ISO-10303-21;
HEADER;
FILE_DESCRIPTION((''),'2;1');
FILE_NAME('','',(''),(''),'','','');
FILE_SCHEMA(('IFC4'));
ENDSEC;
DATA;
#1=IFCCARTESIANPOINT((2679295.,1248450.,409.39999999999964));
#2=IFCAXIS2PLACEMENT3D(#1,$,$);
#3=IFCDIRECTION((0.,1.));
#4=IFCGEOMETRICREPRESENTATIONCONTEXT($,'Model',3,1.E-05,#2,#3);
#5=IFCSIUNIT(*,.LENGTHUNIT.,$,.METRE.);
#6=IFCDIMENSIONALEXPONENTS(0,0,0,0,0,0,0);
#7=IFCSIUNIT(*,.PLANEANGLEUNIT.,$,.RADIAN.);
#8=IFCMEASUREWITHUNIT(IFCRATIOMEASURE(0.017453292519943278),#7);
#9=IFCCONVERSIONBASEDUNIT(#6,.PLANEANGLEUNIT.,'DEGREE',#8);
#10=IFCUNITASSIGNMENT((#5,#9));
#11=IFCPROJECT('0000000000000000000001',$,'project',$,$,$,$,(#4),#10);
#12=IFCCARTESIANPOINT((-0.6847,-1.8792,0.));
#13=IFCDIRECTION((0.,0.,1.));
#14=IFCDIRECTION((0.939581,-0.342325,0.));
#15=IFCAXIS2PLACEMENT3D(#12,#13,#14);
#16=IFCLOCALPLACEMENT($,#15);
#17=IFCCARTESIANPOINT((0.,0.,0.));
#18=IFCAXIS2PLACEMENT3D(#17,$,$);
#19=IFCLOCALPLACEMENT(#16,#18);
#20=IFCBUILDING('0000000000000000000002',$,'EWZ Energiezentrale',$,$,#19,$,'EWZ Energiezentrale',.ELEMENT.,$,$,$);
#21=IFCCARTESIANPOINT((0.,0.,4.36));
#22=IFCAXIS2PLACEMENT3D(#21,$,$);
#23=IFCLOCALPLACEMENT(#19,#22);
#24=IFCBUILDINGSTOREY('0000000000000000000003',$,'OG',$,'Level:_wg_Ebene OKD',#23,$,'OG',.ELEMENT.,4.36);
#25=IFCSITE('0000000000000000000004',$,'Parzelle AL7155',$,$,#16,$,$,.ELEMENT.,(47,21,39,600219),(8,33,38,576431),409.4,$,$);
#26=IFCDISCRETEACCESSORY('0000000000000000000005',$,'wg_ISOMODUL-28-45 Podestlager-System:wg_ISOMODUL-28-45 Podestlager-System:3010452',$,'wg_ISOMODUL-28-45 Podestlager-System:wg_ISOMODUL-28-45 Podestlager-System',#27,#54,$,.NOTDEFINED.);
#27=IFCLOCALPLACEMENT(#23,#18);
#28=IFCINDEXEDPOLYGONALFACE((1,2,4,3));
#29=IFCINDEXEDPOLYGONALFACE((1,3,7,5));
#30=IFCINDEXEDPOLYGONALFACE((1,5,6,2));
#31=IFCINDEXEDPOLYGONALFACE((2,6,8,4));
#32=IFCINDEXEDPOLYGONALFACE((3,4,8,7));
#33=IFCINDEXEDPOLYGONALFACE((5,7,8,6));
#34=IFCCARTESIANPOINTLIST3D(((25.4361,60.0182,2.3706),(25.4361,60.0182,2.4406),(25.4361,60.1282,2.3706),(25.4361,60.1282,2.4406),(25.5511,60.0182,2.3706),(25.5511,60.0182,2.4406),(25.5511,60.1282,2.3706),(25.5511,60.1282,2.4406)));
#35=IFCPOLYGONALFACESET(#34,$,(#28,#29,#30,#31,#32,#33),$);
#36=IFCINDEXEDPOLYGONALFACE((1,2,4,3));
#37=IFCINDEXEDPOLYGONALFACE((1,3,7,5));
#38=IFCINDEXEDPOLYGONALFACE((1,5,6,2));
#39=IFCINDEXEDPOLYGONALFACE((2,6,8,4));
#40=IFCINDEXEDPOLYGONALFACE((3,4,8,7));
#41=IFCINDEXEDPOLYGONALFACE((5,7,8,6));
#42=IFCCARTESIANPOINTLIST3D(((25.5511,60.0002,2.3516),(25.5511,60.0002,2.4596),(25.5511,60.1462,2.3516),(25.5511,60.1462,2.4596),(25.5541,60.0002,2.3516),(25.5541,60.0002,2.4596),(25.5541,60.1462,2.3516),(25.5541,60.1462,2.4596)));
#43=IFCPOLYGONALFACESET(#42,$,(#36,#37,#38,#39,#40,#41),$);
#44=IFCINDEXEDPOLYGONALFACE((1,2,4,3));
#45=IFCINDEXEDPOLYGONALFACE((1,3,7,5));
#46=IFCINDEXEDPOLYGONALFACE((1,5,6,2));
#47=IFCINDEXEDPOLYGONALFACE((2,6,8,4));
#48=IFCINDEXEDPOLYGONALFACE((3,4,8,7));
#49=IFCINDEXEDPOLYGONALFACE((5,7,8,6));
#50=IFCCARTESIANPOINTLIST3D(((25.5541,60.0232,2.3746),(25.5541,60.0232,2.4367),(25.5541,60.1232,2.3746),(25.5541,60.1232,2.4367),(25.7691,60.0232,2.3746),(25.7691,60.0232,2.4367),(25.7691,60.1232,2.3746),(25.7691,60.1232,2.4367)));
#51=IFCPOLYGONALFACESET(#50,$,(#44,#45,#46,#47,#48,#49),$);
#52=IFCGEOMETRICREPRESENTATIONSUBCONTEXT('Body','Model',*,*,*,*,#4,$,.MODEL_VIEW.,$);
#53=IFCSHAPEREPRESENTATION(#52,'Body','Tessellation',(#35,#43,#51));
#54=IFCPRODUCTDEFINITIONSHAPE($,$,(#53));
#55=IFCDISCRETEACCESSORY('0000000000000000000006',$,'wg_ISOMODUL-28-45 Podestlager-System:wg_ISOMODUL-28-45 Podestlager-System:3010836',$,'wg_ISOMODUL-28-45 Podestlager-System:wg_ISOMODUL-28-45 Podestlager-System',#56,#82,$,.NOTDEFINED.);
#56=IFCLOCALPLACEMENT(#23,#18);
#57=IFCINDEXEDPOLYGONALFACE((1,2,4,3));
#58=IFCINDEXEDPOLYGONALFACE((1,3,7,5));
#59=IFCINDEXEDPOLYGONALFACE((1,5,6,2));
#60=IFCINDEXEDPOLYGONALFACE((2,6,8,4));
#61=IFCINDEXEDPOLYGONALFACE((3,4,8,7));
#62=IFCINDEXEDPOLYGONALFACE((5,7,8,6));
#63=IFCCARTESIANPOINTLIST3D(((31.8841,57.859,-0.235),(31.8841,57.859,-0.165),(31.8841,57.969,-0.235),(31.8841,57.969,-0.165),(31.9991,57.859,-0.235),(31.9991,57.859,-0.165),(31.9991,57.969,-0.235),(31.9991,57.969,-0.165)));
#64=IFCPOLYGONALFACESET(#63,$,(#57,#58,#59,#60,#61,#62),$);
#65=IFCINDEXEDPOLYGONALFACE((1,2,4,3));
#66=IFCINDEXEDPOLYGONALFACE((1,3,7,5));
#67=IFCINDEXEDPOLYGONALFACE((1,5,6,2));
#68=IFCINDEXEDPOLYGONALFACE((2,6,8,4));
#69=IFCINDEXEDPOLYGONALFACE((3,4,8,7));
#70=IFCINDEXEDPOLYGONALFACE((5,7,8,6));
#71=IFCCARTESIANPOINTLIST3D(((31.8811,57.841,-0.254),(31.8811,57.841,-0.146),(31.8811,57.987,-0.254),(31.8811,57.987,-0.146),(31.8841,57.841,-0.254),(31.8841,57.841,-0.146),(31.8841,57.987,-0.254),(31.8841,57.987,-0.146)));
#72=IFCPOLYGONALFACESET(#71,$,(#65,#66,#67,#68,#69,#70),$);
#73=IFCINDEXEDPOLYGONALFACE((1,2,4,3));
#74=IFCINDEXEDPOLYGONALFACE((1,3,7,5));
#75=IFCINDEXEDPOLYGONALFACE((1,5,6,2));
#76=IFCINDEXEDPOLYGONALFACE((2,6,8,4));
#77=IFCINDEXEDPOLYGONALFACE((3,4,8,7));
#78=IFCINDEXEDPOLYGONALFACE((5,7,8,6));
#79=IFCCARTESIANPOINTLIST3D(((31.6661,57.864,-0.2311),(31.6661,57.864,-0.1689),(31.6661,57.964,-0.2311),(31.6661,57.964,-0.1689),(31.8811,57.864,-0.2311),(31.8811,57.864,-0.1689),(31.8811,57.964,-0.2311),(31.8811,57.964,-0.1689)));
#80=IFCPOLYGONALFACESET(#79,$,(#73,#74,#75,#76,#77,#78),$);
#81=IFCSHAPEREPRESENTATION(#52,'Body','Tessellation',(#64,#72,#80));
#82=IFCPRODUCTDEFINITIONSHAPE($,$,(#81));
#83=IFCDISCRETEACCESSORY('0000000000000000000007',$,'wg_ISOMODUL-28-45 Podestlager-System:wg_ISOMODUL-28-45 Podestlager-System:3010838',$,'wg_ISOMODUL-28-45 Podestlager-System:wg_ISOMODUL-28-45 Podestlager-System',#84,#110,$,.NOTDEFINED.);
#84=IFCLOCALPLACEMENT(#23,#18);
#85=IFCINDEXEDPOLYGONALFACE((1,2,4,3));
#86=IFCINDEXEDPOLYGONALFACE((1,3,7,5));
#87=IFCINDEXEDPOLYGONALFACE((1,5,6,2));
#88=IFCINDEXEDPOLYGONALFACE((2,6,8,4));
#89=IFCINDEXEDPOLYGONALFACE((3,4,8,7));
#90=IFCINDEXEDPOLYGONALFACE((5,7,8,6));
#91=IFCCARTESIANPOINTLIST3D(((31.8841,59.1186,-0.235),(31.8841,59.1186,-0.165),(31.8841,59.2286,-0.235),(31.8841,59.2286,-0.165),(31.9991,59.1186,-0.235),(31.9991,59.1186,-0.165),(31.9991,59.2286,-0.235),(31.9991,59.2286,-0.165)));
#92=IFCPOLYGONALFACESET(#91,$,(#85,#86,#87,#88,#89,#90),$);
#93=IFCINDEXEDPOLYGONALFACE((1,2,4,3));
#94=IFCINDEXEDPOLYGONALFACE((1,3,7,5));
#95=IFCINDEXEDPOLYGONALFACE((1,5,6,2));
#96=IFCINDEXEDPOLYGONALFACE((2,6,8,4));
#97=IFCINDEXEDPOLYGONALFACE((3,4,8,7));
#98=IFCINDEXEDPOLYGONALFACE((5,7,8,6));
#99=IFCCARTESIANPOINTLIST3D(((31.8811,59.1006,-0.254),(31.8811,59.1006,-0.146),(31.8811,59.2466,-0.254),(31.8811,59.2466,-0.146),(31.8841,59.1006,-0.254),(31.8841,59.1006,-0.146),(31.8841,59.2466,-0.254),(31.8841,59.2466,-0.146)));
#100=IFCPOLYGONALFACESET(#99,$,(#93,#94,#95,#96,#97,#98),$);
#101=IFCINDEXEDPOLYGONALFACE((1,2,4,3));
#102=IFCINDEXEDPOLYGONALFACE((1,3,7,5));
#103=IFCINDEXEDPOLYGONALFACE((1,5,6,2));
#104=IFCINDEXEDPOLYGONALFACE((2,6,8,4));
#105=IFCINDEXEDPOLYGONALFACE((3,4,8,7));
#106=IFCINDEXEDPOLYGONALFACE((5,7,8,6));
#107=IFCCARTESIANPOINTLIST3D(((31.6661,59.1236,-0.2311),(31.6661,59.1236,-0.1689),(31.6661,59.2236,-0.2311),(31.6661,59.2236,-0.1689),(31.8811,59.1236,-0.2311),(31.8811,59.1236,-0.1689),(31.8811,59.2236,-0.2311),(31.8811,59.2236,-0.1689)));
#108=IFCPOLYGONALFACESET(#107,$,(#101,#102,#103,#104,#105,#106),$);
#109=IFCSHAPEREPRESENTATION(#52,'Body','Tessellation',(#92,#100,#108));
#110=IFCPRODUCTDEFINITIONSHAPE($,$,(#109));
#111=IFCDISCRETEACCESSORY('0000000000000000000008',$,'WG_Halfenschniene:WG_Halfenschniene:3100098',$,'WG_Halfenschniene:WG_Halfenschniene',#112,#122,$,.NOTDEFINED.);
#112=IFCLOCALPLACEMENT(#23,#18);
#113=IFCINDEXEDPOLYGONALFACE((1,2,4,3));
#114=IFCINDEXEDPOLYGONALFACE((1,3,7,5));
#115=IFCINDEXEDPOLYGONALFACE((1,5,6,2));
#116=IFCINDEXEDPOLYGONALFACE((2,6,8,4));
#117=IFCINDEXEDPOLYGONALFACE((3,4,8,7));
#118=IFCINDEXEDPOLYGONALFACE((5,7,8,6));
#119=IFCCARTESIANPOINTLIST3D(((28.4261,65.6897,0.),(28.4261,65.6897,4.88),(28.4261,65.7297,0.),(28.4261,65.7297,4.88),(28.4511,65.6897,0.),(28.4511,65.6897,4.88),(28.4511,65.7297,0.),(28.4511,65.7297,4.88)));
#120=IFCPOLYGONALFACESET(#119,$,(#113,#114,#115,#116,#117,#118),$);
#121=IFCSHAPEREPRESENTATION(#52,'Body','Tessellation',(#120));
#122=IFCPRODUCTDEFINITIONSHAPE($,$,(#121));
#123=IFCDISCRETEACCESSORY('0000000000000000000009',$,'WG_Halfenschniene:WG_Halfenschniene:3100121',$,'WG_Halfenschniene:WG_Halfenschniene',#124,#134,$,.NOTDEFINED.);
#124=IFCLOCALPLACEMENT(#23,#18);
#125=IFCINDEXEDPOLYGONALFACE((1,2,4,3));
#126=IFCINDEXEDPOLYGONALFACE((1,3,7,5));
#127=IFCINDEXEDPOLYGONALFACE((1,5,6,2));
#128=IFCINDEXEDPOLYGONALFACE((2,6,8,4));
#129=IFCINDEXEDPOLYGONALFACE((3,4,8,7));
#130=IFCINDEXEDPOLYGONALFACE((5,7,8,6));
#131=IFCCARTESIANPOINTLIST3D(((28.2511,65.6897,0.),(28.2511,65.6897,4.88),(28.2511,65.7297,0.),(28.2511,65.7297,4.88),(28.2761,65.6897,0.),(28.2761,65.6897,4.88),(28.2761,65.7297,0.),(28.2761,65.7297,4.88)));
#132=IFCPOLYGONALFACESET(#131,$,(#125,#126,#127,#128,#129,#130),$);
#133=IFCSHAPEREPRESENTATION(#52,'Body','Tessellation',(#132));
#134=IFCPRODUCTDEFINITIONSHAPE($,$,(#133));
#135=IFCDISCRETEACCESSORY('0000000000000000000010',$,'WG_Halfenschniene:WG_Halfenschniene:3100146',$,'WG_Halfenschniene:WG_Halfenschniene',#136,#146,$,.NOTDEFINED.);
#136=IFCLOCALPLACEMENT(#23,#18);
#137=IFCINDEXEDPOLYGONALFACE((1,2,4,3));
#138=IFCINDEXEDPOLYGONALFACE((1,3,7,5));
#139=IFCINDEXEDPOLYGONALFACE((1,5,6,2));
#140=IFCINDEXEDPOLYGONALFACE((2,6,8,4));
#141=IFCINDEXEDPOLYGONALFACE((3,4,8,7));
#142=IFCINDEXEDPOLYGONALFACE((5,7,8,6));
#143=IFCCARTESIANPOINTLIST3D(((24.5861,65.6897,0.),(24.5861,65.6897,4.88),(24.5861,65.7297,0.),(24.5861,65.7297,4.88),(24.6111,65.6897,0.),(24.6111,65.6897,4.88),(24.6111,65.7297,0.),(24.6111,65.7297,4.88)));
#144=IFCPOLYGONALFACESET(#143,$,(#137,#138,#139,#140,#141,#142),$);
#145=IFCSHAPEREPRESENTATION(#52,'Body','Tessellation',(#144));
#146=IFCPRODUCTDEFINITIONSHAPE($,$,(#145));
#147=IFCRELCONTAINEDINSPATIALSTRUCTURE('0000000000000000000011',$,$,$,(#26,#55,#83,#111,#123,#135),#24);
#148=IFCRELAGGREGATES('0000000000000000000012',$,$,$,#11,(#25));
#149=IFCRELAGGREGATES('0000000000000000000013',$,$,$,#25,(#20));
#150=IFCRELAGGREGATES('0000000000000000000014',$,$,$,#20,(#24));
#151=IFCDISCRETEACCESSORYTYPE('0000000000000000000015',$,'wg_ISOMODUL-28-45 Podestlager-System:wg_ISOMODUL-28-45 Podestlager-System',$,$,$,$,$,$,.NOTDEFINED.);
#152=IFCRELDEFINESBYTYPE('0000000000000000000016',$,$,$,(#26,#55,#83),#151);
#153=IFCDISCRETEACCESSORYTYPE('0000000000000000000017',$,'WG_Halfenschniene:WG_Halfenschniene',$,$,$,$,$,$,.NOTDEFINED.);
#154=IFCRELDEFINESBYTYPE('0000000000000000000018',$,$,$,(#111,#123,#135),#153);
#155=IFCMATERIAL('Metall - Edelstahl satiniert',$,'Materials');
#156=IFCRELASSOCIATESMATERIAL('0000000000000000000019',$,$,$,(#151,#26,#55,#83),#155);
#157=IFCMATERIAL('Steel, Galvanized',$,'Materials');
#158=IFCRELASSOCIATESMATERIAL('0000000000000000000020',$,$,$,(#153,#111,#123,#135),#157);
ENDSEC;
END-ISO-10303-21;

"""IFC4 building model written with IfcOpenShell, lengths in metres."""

from ifc_helpers import new_model, entity, si_unit, converted_unit, direction, frame, origin, place, context, subcontext, project, spatial, indexed_curve, outline, extrude, source, transform, mapped, material, type_object, element, save


model = new_model("IFC4")

# Units and contexts
model_context = context("Model", 3, precision=1e-05, world=frame((2679295.0, 1248450.0, 409.39999999999964)), true_north=direction((0.0, 1.0)))
body_context = subcontext(model_context, "Body", "Model", "MODEL_VIEW")
ifc_project = project(units=[si_unit("LENGTHUNIT", "METRE"), converted_unit("PLANEANGLEUNIT", "DEGREE", entity("IfcRatioMeasure", 0.017453292519943278), si_unit("PLANEANGLEUNIT", "RADIAN"), dimensions=[0, 0, 0, 0, 0, 0, 0])], contexts=[model_context])

# Site, building, storey
site_placement = place(None, frame((-0.6847, -1.8792, 0.0), z_axis=(0.0, 0.0, 1.0), x_axis=(0.939581, -0.342325, 0.0)))
site = spatial("IfcSite", under=ifc_project, at=site_placement, Name="Parzelle AL7155", CompositionType="ELEMENT", RefLatitude=(47, 21, 39, 600219), RefLongitude=(8, 33, 38, 576431), RefElevation=409.4)
building_placement = place(site_placement, origin())
building = spatial("IfcBuilding", under=site, at=building_placement, Name="EWZ Energiezentrale", LongName="EWZ Energiezentrale", CompositionType="ELEMENT")
storey_placement = place(building_placement, frame((0.0, 0.0, 4.36)))
storey = spatial("IfcBuildingStorey", under=building, at=storey_placement, Name="OG", ObjectType="Level:_wg_Ebene OKD", LongName="OG", CompositionType="ELEMENT", Elevation=4.36)

# Discrete accessories
ifc_material_1 = material(Name="Metall - Edelstahl satiniert", Category="Materials")
discrete_accessory_type_1 = type_object("IfcDiscreteAccessoryType", Name="wg_ISOMODUL-28-45 Podestlager-System:wg_ISOMODUL-28-45 Podestlager-System", PredefinedType="NOTDEFINED", material=ifc_material_1)
shared_shape_1 = source(origin(), body_context, "Body", "SweptSolid", [
    extrude(outline(indexed_curve([(-0.0575, -0.055), (0.0575, -0.055), (0.0575, 0.055), (-0.0575, 0.055), (-0.0575, -0.055)], self_intersect=False)), frame((0.0, 0.0575, 0.0), z_axis=(0.0, 0.0, 1.0), x_axis=(0.0, 1.0, 0.0)), (0.0, 0.0, 1.0), 0.07),
    extrude(outline(indexed_curve([(-0.0015, -0.073), (0.0015, -0.073), (0.0015, 0.073), (-0.0015, 0.073), (-0.0015, -0.073)], self_intersect=False)), frame((0.0, -0.0015, -0.019), z_axis=(0.0, 0.0, 1.0), x_axis=(0.0, 1.0, 0.0)), (0.0, 0.0, 1.0), 0.108),
    extrude(outline(indexed_curve([(-0.1075, -0.05), (0.1075, -0.05), (0.1075, 0.05), (-0.1075, 0.05), (-0.1075, -0.05)], self_intersect=False)), frame((0.0, -0.1105, 0.0039), z_axis=(0.0, 0.0, 1.0), x_axis=(0.0, 1.0, 0.0)), (0.0, 0.0, 1.0), 0.0621),
])
for number, where, z_axis, x_axis, name in (
    (1, (25.5511, 60.0732, 2.3706), (0.0, 0.0, 1.0), (0.0, 1.0, 0.0), "wg_ISOMODUL-28-45 Podestlager-System:wg_ISOMODUL-28-45 Podestlager-System:3010452"),
    (2, (31.8841, 57.914, -0.235), (0.0, 0.0, 1.0), (0.0, -1.0, 0.0), "wg_ISOMODUL-28-45 Podestlager-System:wg_ISOMODUL-28-45 Podestlager-System:3010836"),
    (3, (31.8841, 59.1736, -0.235), (0.0, 0.0, 1.0), (0.0, -1.0, 0.0), "wg_ISOMODUL-28-45 Podestlager-System:wg_ISOMODUL-28-45 Podestlager-System:3010838"),
):
    element("IfcDiscreteAccessory", number, at=place(storey_placement, frame(where, z_axis=z_axis, x_axis=x_axis)), inside=storey, type_object=discrete_accessory_type_1, material=ifc_material_1, Name=name, ObjectType="wg_ISOMODUL-28-45 Podestlager-System:wg_ISOMODUL-28-45 Podestlager-System", PredefinedType="NOTDEFINED", context=body_context, shape_type="MappedRepresentation", body=[
        mapped(shared_shape_1, transform((0.0, 0.0, 0.0), scale=1.0)),
    ])
ifc_material_2 = material(Name="Steel, Galvanized", Category="Materials")
discrete_accessory_type_2 = type_object("IfcDiscreteAccessoryType", Name="WG_Halfenschniene:WG_Halfenschniene", PredefinedType="NOTDEFINED", material=ifc_material_2)
shared_shape_2 = source(origin(), body_context, "Body", "SweptSolid", [
    extrude(outline(indexed_curve([(-2.44, -0.02), (2.44, -0.02), (2.44, 0.02), (-2.44, 0.02), (-2.44, -0.02)], self_intersect=False)), frame((2.44, 0.0, -0.0125)), (0.0, 0.0, 1.0), 0.025),
])
for number, where, z_axis, x_axis, name in (
    (4, (28.4386, 65.7097, 4.88), (1.0, 0.0, 0.0), (0.0, 0.0, -1.0), "WG_Halfenschniene:WG_Halfenschniene:3100098"),
    (5, (28.2636, 65.7097, 0.0), (-1.0, 0.0, 0.0), (0.0, 0.0, 1.0), "WG_Halfenschniene:WG_Halfenschniene:3100121"),
    (6, (24.5986, 65.7097, 4.88), (1.0, 0.0, 0.0), (0.0, 0.0, -1.0), "WG_Halfenschniene:WG_Halfenschniene:3100146"),
):
    element("IfcDiscreteAccessory", number, at=place(storey_placement, frame(where, z_axis=z_axis, x_axis=x_axis)), inside=storey, type_object=discrete_accessory_type_2, material=ifc_material_2, Name=name, ObjectType="WG_Halfenschniene:WG_Halfenschniene", PredefinedType="NOTDEFINED", context=body_context, shape_type="MappedRepresentation", body=[
        mapped(shared_shape_2, transform((0.0, 0.0, 0.0), scale=1.0)),
    ])

save(model, "model.ifc")
